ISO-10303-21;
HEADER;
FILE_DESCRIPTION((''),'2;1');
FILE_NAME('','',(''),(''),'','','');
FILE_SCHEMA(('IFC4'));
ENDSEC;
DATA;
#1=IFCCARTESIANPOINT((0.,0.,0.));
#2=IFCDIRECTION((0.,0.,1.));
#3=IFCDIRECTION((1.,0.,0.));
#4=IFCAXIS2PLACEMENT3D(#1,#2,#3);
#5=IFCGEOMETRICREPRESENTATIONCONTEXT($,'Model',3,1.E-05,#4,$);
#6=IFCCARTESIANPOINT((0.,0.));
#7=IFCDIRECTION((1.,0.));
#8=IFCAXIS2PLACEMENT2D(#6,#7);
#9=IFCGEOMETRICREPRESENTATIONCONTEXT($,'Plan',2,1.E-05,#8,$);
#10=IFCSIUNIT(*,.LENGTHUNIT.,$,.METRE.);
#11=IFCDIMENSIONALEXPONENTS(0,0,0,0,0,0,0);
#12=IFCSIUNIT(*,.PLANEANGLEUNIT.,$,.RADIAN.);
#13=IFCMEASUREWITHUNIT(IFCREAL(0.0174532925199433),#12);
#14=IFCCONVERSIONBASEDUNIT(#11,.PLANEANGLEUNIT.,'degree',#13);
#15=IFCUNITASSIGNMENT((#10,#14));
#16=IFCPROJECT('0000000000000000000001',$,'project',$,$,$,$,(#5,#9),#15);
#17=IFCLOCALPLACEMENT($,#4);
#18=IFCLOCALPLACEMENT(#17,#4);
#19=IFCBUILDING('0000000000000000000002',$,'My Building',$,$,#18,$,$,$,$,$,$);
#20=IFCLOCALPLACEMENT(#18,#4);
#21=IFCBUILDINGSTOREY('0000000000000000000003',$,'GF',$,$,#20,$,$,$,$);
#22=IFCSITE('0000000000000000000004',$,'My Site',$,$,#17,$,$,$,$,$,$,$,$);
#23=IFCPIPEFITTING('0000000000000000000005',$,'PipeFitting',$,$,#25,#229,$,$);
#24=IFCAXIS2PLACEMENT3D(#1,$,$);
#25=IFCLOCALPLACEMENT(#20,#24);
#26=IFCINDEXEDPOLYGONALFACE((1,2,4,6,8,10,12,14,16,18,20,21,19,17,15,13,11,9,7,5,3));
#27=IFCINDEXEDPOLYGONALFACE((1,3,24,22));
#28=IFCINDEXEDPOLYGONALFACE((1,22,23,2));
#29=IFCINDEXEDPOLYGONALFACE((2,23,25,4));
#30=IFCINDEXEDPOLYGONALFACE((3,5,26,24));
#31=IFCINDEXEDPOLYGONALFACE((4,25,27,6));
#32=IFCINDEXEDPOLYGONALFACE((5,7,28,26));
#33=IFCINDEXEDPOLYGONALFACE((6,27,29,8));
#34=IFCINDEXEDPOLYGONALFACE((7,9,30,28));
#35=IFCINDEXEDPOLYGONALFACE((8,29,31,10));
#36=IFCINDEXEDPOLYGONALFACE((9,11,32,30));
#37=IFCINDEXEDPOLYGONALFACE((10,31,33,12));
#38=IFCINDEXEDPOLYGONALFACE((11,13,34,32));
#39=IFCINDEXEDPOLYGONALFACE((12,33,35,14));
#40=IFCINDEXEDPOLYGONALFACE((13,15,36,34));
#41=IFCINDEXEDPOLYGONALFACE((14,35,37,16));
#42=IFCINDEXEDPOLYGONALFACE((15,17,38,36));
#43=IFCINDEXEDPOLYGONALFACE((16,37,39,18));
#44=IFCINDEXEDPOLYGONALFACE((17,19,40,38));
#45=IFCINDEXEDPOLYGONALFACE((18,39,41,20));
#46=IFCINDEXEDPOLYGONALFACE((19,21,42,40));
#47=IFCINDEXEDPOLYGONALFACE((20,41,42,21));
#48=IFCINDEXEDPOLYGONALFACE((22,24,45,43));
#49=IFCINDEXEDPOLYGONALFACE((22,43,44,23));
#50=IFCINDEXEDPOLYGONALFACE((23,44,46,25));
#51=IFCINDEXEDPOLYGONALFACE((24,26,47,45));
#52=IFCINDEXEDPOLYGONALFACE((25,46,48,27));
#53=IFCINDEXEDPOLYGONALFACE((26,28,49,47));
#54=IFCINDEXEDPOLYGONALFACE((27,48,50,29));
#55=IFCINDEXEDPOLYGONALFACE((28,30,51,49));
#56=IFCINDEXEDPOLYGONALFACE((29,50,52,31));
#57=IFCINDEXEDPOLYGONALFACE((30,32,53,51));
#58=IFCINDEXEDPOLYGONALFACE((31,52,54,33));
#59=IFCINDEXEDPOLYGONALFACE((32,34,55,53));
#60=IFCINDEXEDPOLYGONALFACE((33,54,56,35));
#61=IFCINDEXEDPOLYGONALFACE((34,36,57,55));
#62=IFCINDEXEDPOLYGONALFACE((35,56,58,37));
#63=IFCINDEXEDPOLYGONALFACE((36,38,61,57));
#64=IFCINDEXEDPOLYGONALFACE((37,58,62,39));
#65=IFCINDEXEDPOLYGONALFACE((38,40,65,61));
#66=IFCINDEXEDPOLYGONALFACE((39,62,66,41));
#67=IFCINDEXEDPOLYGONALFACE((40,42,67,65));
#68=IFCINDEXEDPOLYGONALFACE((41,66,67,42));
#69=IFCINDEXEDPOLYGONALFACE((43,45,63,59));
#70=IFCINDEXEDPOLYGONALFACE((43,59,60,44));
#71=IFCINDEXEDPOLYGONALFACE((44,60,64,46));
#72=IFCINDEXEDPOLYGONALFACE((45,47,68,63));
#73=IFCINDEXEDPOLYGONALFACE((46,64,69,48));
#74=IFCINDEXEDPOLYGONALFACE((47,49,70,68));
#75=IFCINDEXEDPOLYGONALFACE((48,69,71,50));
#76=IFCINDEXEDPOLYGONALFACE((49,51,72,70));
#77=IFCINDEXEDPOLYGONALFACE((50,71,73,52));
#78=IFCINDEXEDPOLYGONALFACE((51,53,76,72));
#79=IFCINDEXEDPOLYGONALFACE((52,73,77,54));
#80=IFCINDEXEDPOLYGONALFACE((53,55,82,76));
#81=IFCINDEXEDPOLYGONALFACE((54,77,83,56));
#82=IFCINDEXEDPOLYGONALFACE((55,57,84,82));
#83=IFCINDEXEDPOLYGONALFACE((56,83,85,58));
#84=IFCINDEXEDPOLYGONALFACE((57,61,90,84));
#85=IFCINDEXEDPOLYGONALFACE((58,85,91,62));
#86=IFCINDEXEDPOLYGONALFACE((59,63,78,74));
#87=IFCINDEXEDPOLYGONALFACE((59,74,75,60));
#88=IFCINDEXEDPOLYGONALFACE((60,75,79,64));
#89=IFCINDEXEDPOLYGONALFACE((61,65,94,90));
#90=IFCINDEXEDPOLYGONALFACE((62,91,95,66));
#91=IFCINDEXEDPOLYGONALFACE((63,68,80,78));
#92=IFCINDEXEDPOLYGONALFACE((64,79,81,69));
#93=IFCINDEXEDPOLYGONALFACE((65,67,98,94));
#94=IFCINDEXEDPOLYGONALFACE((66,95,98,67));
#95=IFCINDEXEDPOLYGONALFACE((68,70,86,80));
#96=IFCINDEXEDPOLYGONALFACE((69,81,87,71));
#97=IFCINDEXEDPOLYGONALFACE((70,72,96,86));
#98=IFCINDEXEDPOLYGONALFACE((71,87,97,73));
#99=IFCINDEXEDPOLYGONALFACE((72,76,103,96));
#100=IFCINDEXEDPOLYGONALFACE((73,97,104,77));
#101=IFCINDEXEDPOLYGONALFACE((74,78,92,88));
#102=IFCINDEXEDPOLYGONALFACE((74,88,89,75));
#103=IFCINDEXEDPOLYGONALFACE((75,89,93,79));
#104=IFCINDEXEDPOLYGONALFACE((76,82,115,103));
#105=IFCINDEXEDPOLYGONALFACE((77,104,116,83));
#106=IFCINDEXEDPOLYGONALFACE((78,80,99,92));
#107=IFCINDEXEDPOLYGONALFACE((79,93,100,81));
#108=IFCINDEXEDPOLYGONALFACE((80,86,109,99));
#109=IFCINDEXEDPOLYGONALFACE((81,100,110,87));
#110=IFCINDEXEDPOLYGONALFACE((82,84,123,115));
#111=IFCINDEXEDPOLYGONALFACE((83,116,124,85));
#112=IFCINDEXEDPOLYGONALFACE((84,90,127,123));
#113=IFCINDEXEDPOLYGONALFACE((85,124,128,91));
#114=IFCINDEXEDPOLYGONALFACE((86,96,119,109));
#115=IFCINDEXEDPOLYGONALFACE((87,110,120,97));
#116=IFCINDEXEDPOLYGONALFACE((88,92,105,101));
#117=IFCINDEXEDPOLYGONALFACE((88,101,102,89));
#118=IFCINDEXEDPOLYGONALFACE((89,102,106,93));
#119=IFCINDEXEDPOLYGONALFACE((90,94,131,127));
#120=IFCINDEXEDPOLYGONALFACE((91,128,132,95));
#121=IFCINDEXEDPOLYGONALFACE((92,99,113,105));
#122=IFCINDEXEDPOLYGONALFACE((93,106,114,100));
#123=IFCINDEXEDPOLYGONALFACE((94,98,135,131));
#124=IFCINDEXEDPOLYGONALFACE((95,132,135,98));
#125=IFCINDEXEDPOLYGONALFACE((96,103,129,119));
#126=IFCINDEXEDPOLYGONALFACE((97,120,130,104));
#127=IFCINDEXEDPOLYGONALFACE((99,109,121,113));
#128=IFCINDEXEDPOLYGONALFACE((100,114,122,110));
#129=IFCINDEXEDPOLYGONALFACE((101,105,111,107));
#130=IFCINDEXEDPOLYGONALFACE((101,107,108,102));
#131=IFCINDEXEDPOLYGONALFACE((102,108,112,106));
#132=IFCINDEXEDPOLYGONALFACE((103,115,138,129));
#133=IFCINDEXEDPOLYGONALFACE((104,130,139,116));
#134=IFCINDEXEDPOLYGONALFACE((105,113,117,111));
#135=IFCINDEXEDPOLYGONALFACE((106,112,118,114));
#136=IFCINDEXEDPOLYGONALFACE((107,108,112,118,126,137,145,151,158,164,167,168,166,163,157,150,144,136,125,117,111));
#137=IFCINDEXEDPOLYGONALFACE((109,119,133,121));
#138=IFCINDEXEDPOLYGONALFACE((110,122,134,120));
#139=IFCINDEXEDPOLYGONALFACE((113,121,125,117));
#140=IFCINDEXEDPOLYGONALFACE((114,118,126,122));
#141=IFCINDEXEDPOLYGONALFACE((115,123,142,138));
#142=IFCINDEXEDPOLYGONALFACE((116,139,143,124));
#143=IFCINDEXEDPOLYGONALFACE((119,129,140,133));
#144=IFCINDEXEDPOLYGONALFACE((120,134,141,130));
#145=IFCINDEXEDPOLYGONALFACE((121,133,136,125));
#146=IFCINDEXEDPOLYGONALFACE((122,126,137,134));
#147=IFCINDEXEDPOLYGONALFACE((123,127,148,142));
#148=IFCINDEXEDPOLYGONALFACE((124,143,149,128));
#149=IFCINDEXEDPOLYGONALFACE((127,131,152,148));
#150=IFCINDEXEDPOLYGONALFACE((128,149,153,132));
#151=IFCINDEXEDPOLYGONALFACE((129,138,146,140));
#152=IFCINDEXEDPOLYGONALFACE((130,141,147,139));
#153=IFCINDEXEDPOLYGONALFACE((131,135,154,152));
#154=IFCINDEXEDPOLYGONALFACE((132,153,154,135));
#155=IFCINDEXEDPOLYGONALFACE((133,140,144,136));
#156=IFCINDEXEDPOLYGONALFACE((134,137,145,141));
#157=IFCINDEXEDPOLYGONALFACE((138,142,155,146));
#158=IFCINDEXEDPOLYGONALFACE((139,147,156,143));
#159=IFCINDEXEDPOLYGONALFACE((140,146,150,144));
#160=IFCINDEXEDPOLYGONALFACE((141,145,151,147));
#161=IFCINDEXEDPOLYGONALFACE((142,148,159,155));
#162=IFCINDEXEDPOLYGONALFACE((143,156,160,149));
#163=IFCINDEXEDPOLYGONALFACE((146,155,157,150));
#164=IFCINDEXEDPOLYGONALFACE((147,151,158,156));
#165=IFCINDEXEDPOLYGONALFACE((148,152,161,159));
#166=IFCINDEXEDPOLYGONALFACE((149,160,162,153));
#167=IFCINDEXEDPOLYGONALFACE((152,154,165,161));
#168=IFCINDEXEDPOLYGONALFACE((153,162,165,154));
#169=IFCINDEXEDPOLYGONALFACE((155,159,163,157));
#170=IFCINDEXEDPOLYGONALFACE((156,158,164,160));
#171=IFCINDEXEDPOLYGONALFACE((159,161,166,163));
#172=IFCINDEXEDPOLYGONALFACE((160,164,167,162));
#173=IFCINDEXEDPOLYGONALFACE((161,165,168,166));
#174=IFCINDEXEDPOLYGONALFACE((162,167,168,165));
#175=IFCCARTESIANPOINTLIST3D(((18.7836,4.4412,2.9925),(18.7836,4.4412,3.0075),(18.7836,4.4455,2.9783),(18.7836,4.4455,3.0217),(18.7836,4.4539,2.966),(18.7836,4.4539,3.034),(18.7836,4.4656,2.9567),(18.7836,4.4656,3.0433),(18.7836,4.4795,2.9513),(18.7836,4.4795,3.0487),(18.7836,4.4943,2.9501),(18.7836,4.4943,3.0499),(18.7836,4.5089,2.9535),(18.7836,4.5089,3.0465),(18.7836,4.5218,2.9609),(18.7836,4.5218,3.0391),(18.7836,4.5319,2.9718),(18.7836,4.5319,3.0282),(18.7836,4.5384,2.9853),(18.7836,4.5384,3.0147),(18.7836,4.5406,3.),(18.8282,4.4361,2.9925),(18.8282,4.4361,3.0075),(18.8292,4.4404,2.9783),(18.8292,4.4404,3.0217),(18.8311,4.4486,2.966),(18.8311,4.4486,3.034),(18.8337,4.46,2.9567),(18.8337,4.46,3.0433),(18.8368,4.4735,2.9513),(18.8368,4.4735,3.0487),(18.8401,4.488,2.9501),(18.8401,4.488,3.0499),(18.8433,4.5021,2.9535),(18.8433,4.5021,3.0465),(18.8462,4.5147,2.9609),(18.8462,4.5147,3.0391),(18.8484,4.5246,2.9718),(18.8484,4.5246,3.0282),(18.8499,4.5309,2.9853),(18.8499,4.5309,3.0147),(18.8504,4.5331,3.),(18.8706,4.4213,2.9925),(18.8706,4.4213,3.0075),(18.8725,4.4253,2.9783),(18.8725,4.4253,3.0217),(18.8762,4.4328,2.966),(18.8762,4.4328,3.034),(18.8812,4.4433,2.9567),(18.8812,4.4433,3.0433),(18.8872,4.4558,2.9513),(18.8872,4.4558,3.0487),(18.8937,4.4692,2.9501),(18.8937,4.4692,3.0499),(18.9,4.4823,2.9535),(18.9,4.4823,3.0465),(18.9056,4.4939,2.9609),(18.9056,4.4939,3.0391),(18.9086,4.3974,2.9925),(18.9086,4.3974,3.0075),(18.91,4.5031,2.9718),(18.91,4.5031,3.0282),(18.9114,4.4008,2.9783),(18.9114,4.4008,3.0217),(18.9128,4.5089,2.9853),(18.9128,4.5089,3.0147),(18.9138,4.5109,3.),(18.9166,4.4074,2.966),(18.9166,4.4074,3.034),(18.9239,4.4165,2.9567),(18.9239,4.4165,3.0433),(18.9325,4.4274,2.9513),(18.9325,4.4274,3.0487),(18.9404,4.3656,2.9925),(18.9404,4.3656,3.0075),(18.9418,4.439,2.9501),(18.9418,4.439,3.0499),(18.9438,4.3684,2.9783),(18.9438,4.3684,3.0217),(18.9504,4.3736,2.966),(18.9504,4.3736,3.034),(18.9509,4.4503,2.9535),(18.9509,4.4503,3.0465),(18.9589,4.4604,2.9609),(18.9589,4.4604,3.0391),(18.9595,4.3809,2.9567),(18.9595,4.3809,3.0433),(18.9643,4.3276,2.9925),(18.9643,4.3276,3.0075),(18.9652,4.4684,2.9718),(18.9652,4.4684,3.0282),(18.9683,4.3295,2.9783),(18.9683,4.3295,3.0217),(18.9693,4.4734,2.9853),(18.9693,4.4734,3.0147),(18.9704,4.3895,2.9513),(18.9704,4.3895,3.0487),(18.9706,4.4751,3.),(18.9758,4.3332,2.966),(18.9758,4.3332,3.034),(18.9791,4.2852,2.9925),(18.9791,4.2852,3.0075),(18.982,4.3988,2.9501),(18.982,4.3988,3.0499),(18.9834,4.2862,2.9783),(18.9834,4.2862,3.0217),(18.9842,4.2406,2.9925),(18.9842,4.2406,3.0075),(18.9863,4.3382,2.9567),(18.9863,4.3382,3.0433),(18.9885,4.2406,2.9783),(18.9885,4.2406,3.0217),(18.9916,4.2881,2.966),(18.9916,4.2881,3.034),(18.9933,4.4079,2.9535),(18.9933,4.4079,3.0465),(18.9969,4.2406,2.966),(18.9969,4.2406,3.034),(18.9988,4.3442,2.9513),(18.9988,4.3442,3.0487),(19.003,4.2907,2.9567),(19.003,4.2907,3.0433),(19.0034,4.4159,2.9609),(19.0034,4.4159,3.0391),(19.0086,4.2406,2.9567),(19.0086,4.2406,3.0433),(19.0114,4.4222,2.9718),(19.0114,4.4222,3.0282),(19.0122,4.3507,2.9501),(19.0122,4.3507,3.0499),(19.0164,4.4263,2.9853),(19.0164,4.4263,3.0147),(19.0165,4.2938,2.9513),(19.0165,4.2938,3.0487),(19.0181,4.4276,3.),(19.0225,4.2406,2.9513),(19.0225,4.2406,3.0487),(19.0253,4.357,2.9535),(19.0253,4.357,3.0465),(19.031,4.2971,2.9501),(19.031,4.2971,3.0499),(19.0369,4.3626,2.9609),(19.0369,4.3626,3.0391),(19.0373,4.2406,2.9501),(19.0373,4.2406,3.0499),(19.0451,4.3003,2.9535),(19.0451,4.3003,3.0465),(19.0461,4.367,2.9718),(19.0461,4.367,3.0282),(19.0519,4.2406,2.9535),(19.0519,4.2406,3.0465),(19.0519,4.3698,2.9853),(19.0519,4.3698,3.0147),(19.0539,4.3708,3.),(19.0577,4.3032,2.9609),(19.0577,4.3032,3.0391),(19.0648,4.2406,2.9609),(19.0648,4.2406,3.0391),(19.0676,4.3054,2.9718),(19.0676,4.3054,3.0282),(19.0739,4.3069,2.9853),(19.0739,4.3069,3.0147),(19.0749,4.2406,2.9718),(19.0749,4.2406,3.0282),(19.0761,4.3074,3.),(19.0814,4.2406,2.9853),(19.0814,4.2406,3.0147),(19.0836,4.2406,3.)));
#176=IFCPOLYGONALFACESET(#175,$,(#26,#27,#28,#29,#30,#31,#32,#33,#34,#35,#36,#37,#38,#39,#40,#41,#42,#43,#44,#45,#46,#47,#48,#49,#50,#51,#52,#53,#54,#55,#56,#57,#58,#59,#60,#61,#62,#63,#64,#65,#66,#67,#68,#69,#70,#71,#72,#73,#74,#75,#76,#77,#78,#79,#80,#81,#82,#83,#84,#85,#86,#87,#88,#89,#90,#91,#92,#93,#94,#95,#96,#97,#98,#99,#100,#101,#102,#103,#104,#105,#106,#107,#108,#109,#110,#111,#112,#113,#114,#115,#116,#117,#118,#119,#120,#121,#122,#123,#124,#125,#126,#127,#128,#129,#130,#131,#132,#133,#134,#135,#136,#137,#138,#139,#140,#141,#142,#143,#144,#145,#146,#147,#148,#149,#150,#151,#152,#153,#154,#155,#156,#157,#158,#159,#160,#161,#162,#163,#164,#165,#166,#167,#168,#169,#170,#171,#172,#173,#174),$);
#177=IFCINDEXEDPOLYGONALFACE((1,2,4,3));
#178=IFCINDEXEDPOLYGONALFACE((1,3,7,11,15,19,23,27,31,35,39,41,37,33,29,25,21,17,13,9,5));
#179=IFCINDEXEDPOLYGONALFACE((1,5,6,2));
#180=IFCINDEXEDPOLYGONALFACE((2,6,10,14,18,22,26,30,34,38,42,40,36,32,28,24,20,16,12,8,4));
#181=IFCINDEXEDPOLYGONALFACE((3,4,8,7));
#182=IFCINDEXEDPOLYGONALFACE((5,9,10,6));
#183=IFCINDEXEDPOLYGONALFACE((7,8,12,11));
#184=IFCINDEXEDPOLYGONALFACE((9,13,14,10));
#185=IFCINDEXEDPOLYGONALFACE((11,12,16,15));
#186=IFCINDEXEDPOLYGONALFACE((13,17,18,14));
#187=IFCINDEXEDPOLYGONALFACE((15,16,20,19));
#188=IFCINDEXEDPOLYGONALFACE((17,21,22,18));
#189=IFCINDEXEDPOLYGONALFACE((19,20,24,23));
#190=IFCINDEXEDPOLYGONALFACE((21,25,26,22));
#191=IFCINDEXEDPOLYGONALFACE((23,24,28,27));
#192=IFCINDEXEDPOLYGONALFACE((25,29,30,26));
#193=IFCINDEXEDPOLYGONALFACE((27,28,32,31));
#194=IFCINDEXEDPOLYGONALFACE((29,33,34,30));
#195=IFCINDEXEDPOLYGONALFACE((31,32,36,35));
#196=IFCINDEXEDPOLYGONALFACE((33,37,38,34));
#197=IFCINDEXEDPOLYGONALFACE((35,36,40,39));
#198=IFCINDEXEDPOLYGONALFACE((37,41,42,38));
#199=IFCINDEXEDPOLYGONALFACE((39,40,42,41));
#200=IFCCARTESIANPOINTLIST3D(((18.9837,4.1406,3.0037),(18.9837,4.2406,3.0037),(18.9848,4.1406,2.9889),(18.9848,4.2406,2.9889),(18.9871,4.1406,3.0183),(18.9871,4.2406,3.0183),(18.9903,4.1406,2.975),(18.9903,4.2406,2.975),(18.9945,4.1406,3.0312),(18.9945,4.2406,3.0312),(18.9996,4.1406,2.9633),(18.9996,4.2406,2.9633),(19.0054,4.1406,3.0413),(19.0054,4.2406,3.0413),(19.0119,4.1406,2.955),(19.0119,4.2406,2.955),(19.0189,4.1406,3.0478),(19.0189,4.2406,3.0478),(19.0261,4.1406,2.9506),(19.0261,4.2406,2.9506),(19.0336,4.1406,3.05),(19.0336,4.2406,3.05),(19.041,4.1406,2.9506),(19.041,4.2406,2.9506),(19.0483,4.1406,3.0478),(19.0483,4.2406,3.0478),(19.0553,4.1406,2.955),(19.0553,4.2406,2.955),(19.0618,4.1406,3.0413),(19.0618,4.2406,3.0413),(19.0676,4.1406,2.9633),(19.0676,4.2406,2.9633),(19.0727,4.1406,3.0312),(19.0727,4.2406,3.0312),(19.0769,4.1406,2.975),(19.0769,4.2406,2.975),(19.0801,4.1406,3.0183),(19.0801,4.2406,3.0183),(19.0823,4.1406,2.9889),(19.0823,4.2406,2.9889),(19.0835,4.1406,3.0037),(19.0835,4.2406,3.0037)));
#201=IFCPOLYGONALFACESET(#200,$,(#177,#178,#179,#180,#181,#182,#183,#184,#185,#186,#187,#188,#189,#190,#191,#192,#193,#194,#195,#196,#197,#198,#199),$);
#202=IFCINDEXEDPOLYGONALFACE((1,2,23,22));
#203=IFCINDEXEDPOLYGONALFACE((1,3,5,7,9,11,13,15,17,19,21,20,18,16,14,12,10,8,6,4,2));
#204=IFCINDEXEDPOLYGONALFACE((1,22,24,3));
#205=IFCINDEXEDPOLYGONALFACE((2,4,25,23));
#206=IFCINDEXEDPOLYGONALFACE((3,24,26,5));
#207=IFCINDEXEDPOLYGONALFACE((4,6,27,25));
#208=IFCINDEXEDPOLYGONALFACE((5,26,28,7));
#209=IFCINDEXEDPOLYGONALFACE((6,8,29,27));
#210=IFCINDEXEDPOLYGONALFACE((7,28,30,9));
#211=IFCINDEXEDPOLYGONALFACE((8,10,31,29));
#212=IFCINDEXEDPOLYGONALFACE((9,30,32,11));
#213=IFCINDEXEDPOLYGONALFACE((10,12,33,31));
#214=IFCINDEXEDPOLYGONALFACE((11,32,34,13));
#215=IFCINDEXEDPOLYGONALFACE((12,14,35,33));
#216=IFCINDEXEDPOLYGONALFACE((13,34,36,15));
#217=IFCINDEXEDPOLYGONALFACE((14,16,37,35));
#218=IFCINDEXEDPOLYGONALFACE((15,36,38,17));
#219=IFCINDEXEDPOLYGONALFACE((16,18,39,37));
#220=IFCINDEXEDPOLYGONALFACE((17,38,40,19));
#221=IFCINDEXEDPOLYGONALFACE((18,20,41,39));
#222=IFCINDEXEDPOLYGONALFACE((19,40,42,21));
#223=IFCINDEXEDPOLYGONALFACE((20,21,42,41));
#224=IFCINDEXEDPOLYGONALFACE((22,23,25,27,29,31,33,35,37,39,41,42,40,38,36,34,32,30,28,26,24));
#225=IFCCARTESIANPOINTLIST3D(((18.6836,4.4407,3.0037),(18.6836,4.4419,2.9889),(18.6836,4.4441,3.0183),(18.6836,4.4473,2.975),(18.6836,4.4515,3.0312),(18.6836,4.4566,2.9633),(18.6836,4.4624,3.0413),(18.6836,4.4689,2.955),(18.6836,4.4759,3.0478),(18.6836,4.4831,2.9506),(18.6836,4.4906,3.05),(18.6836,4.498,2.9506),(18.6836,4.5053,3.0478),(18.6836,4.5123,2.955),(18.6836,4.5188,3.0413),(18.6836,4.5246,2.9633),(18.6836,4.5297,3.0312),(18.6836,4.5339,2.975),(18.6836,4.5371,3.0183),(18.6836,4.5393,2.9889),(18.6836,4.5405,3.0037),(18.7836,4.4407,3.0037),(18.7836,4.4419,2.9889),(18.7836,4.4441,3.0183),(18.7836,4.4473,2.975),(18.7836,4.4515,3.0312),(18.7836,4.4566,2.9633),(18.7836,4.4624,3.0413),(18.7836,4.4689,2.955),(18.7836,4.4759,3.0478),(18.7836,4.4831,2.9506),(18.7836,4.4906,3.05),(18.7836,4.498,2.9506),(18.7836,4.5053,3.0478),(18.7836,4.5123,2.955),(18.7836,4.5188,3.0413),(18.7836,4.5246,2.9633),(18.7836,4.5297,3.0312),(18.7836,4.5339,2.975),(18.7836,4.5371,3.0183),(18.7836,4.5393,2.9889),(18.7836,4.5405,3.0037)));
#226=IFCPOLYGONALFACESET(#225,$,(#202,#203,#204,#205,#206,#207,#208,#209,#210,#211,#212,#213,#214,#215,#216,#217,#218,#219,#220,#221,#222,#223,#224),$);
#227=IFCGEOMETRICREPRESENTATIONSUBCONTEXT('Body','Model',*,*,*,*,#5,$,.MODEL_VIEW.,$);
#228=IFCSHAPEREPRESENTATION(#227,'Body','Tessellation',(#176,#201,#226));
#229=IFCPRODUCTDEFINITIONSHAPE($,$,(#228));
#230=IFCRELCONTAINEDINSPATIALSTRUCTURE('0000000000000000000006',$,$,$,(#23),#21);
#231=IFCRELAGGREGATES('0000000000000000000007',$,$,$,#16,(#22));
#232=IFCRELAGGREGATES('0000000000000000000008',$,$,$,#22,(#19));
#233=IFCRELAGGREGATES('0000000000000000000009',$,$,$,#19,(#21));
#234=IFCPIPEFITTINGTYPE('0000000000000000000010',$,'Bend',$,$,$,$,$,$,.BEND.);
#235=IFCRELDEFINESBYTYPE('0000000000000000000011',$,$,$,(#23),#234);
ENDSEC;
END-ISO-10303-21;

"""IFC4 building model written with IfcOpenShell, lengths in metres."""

from ifc_helpers import new_model, entity, si_unit, converted_unit, frame, origin_with_axes, origin_2d_with_axis, place, context, subcontext, project, spatial, circle, extrude, source, transform, mapped, type_object, type_shapes, element, save


model = new_model("IFC4")

# Units and contexts
model_context = context("Model", 3, precision=1e-05, world=origin_with_axes())
plan_context = context("Plan", 2, precision=1e-05, world=origin_2d_with_axis())
body_context_1 = subcontext(model_context, "Body", "Model", "MODEL_VIEW")
ifc_project = project(units=[si_unit("LENGTHUNIT", "METRE"), converted_unit("PLANEANGLEUNIT", "degree", entity("IfcReal", 0.0174532925199433), si_unit("PLANEANGLEUNIT", "RADIAN"), dimensions=[0, 0, 0, 0, 0, 0, 0])], contexts=[model_context, plan_context])

# Site, building, storey
site_placement = place(None, origin_with_axes())
site = spatial("IfcSite", under=ifc_project, at=site_placement, Name="My Site")
building_placement = place(site_placement, origin_with_axes())
building = spatial("IfcBuilding", under=site, at=building_placement, Name="My Building")
storey_placement = place(building_placement, origin_with_axes())
storey = spatial("IfcBuildingStorey", under=building, at=storey_placement, Name="GF")

# Pipe fitting
pipe_fitting_type = type_object("IfcPipeFittingType", Name="Bend", PredefinedType="BEND")
shared_shape_1 = source(origin_with_axes(), body_context_1, "Body", "SolidModel", [
    entity("IfcSweptDiskSolid", entity("IfcIndexedPolyCurve", entity("IfcCartesianPointList3D", [[0.0, 0.0, 0.1], [0.0, -0.0732, 0.2768], [0.0, -0.25, 0.35]]), [entity("IfcArcIndex", [1, 2, 3])]), 0.05),
    extrude(circle(Radius=0.05), origin_with_axes(), (0.0, 0.0, 1.0), 0.1),
    extrude(circle(Radius=0.05), frame((0.0, -0.25, 0.35), z_axis=(0.0, -1.0, 0.0), x_axis=(1.0, 0.0, 0.0)), (0.0, 0.0, 1.0), 0.1),
])
type_shapes(pipe_fitting_type, [shared_shape_1])
for number, where, z_axis, x_axis, name in (
    (1, (19.0336, 4.1406, 3.0), (0.0, 1.0, 0.0), (0.0, 0.0, 1.0), "PipeFitting"),
):
    element("IfcPipeFitting", number, at=place(storey_placement, frame(where, z_axis=z_axis, x_axis=x_axis)), inside=storey, type_object=pipe_fitting_type, Name=name, context=body_context_1, shape_type="MappedRepresentation", body=[
        mapped(shared_shape_1, transform((0.0, 0.0, 0.0), x_axis=(1.0, 0.0, 0.0), y_axis=(0.0, 1.0, 0.0), z_axis=(0.0, 0.0, 1.0), scale=1.0)),
    ])

save(model, "model.ifc")
